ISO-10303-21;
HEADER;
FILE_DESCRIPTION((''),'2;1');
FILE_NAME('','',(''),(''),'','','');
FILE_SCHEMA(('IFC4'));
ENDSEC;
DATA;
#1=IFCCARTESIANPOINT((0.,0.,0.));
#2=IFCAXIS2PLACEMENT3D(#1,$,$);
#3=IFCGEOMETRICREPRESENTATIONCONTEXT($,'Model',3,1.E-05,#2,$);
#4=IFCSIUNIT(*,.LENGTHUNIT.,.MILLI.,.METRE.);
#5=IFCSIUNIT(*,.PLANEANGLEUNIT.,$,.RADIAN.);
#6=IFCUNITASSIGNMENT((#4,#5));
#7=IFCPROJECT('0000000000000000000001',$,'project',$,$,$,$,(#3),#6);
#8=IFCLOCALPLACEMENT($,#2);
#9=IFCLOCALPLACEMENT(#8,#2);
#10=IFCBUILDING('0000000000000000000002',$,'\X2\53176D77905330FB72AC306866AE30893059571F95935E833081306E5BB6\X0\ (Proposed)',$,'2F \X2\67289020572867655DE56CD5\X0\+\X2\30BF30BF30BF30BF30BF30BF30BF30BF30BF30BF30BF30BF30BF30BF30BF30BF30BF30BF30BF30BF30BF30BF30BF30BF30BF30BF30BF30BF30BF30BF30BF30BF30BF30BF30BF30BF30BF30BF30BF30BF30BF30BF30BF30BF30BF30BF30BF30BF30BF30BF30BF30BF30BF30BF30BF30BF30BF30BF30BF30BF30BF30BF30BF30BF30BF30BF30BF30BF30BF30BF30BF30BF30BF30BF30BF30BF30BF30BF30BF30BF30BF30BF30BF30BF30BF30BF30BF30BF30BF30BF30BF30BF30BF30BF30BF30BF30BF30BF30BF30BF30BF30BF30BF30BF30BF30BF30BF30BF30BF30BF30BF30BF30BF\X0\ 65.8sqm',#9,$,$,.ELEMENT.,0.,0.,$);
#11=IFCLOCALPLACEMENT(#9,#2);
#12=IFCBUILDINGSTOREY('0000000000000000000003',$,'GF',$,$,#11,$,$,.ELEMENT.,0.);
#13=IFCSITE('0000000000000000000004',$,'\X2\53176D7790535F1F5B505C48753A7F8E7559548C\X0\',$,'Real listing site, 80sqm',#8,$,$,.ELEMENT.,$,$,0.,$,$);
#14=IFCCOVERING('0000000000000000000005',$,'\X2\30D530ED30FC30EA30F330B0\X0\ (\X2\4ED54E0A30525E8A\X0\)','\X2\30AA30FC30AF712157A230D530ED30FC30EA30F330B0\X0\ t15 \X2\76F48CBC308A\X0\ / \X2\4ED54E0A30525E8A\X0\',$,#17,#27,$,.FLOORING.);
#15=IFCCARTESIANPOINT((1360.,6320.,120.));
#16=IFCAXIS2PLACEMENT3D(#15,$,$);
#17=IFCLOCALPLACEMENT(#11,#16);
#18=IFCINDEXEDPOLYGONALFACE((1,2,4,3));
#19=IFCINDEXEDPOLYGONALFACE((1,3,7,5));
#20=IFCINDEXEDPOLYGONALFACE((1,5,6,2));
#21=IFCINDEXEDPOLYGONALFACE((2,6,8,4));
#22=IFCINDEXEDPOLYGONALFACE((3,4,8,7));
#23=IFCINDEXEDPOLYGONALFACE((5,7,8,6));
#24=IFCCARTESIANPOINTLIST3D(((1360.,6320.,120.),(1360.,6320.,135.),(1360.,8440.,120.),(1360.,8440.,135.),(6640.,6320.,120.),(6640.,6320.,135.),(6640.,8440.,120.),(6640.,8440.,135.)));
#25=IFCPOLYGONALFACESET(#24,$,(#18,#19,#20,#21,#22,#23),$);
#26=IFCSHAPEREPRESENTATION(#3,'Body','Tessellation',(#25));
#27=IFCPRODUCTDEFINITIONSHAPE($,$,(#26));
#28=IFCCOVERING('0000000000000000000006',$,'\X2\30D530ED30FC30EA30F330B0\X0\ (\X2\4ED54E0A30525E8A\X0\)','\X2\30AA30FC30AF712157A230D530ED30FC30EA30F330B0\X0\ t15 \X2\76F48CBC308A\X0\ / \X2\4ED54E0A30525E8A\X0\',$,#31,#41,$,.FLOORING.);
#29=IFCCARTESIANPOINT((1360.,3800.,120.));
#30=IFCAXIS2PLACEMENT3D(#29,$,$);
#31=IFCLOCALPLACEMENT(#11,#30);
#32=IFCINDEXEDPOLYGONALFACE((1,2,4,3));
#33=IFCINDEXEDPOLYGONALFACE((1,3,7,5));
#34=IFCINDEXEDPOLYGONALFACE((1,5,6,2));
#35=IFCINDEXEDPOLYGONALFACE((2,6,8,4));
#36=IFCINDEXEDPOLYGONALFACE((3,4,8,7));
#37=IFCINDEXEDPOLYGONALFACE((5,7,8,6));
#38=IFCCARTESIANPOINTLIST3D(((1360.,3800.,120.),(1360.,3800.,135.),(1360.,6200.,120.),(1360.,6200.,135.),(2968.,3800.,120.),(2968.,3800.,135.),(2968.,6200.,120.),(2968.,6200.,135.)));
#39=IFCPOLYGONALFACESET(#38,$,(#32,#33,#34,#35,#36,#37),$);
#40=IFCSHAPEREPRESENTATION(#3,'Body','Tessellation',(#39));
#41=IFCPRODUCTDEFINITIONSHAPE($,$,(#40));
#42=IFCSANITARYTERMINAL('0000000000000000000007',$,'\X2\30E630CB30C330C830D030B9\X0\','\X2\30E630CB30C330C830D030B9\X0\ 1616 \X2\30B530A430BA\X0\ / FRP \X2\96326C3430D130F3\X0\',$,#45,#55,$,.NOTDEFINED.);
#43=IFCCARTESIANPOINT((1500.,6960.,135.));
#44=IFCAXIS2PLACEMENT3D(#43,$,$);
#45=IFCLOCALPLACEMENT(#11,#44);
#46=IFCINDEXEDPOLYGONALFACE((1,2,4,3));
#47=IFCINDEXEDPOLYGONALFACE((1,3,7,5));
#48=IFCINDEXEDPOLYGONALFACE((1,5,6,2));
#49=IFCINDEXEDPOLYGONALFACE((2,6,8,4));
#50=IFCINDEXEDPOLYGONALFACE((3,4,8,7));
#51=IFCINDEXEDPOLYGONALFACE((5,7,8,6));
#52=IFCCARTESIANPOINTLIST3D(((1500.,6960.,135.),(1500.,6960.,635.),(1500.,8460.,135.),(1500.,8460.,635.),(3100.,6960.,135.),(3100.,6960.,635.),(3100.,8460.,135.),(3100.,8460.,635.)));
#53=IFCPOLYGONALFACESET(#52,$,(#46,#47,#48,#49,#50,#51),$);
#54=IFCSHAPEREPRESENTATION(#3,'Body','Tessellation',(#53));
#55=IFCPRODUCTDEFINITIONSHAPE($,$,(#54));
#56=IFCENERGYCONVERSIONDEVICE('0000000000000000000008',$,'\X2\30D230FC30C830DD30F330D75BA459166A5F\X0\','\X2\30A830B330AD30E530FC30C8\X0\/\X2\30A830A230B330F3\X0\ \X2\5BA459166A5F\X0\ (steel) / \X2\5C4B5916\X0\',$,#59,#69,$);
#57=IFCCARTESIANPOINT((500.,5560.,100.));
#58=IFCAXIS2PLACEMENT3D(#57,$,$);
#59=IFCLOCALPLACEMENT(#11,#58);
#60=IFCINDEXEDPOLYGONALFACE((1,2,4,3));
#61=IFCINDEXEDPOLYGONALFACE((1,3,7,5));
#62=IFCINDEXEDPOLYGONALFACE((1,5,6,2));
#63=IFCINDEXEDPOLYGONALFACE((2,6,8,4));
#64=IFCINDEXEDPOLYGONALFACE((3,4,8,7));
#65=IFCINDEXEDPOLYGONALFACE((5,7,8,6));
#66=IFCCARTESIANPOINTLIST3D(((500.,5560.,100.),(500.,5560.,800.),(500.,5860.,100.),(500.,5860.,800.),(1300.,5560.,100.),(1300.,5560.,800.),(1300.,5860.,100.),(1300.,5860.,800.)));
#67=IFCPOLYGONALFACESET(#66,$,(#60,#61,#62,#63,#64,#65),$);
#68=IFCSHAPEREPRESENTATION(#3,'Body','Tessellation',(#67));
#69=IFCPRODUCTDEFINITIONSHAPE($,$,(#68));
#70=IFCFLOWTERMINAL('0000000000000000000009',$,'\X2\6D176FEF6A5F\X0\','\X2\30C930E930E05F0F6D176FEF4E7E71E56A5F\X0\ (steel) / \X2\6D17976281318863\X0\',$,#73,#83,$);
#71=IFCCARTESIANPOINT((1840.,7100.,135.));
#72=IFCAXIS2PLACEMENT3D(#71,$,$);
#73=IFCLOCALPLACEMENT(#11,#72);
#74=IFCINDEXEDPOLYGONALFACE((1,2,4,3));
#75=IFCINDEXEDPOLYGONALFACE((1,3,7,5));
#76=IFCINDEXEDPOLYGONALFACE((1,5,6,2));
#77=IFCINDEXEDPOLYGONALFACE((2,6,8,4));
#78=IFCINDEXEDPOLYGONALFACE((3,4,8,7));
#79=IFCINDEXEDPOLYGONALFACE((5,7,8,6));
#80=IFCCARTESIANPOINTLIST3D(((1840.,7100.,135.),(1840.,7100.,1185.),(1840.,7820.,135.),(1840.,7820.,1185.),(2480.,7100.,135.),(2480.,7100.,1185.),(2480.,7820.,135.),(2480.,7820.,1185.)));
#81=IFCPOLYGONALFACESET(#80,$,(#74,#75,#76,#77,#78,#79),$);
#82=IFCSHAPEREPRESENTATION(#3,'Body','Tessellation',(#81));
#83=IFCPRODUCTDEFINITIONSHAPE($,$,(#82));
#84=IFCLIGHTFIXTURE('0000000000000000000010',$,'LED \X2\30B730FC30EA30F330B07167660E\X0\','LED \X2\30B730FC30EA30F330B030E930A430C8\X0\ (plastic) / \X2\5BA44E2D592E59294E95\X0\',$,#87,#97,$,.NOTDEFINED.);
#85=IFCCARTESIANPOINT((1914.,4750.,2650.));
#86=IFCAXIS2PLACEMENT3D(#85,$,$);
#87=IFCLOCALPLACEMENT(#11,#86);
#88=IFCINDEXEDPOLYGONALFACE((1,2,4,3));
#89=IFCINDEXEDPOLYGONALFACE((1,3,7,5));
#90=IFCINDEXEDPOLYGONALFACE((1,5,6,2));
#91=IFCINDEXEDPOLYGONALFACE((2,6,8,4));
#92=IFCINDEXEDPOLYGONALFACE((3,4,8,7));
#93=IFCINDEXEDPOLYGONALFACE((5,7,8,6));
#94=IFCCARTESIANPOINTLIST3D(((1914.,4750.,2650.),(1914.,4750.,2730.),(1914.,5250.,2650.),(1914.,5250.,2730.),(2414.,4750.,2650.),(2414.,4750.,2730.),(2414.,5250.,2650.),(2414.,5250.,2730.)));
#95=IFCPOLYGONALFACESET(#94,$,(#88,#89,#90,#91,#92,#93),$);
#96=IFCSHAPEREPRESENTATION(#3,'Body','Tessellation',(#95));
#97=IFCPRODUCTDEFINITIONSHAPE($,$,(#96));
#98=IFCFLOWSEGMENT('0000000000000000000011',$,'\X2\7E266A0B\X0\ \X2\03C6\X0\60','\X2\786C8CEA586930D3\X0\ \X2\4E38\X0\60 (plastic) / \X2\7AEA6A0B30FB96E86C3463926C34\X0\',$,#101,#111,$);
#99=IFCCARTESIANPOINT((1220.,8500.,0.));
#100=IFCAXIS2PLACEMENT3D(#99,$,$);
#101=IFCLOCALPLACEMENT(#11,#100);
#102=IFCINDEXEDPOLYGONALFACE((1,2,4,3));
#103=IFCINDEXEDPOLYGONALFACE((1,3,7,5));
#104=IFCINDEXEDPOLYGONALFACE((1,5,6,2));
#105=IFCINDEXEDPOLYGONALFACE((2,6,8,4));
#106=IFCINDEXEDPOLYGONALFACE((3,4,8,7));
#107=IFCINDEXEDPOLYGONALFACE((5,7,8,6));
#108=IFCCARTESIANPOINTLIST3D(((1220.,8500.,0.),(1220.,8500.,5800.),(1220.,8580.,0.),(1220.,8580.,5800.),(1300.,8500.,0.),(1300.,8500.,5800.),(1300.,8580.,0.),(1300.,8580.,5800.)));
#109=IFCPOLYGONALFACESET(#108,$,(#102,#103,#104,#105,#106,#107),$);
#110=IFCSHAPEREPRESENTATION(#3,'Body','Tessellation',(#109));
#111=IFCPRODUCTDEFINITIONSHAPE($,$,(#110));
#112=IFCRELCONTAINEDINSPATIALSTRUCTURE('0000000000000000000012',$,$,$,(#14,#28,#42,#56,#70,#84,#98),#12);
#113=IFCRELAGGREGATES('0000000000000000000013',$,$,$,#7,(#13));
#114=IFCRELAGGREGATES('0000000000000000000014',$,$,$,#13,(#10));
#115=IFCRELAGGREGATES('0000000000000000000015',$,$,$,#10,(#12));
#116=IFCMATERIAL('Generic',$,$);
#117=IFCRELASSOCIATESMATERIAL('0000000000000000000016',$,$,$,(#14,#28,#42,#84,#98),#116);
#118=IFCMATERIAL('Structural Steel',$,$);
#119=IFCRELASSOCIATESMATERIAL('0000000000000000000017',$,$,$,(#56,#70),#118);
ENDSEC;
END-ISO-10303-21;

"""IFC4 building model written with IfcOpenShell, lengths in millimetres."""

from ifc_helpers import new_model, si_unit, frame, frame_2d, origin, place, context, project, spatial, rectangle, extrude, material, element, save


model = new_model("IFC4")

# Units and contexts
model_context = context("Model", 3, precision=1e-05, world=origin())
ifc_project = project(units=[si_unit("LENGTHUNIT", "METRE", prefix="MILLI"), si_unit("PLANEANGLEUNIT", "RADIAN")], contexts=[model_context])

# Site, building, storey
site_placement = place(None, origin())
site = spatial("IfcSite", under=ifc_project, at=site_placement, Name="北海道弟子屈町美留和", ObjectType="Real listing site, 80sqm", CompositionType="ELEMENT", RefElevation=0.0)
building_placement = place(site_placement, origin())
building = spatial("IfcBuilding", under=site, at=building_placement, Name="北海道・犬と暮らす土間広めの家 (Proposed)", ObjectType="2F 木造在来工法+タタタタタタタタタタタタタタタタタタタタタタタタタタタタタタタタタタタタタタタタタタタタタタタタタタタタタタタタタタタタタタタタタタタタタタタタタタタタタタタタタタタタタタタタタタタタタタタタタタタタタタタタタタタタタタタタタ 65.8sqm", CompositionType="ELEMENT", ElevationOfRefHeight=0.0, ElevationOfTerrain=0.0)
storey_placement = place(building_placement, origin())
storey = spatial("IfcBuildingStorey", under=building, at=storey_placement, Name="GF", CompositionType="ELEMENT", Elevation=0.0)

# Coverings
ifc_material_1 = material(Name="Generic")
covering_1_placement = place(storey_placement, frame((1360.0, 6320.0, 120.0)))
element("IfcCovering", 1, at=covering_1_placement, inside=storey, material=ifc_material_1, Name="フローリング (仕上げ床)", Description="オーク無垢フローリング t15 直貼り / 仕上げ床", PredefinedType="FLOORING", context=model_context, shape_type="SweptSolid", body=[
    extrude(rectangle(XDim=5280.0, YDim=2120.0, at=frame_2d((2640.0, 1060.0))), frame((1360.0, 6320.0, 120.0)), (0.0, 0.0, 1.0), 15.0),
])
covering_2_placement = place(storey_placement, frame((1360.0, 3800.0, 120.0)))
element("IfcCovering", 2, at=covering_2_placement, inside=storey, material=ifc_material_1, Name="フローリング (仕上げ床)", Description="オーク無垢フローリング t15 直貼り / 仕上げ床", PredefinedType="FLOORING", context=model_context, shape_type="SweptSolid", body=[
    extrude(rectangle(XDim=1608.0, YDim=2400.0, at=frame_2d((804.0, 1200.0))), frame((1360.0, 3800.0, 120.0)), (0.0, 0.0, 1.0), 15.0),
])

# Sanitary terminal
sanitary_terminal_placement = place(storey_placement, frame((1500.0, 6960.0, 135.0)))
element("IfcSanitaryTerminal", 3, at=sanitary_terminal_placement, inside=storey, material=ifc_material_1, Name="ユニットバス", Description="ユニットバス 1616 サイズ / FRP 防水パン", PredefinedType="NOTDEFINED", context=model_context, shape_type="SweptSolid", body=[
    extrude(rectangle(XDim=1600.0, YDim=1500.0, at=frame_2d((800.0, 750.0))), frame((1500.0, 6960.0, 135.0)), (0.0, 0.0, 1.0), 500.0),
])

# Shared definitions
ifc_material_2 = material(Name="Structural Steel")

# Energy conversion device
energy_conversion_device_placement = place(storey_placement, frame((500.0, 5560.0, 100.0)))
element("IfcEnergyConversionDevice", 4, at=energy_conversion_device_placement, inside=storey, material=ifc_material_2, Name="ヒートポンプ室外機", Description="エコキュート/エアコン 室外機 (steel) / 屋外", context=model_context, shape_type="SweptSolid", body=[
    extrude(rectangle(XDim=800.0, YDim=300.0, at=frame_2d((400.0, 150.0))), frame((500.0, 5560.0, 100.0)), (0.0, 0.0, 1.0), 700.0),
])

# Flow terminal
flow_terminal_placement = place(storey_placement, frame((1840.0, 7100.0, 135.0)))
element("IfcFlowTerminal", 5, at=flow_terminal_placement, inside=storey, material=ifc_material_2, Name="洗濯機", Description="ドラム式洗濯乾燥機 (steel) / 洗面脱衣", context=model_context, shape_type="SweptSolid", body=[
    extrude(rectangle(XDim=640.0, YDim=720.0, at=frame_2d((320.0, 360.0))), frame((1840.0, 7100.0, 135.0)), (0.0, 0.0, 1.0), 1050.0),
])

# Light fixture
light_fixture_placement = place(storey_placement, frame((1914.0, 4750.0, 2650.0)))
element("IfcLightFixture", 6, at=light_fixture_placement, inside=storey, material=ifc_material_1, Name="LED シーリング照明", Description="LED シーリングライト (plastic) / 室中央天井", PredefinedType="NOTDEFINED", context=model_context, shape_type="SweptSolid", body=[
    extrude(rectangle(XDim=500.0, YDim=500.0, at=frame_2d((250.0, 250.0))), frame((1914.0, 4750.0, 2650.0)), (0.0, 0.0, 1.0), 80.0),
])

# Flow segment
flow_segment_placement = place(storey_placement, frame((1220.0, 8500.0, 0.0)))
element("IfcFlowSegment", 7, at=flow_segment_placement, inside=storey, material=ifc_material_1, Name="縦樋 φ60", Description="硬質塩ビ 丸60 (plastic) / 竪樋・雨水排水", context=model_context, shape_type="SweptSolid", body=[
    extrude(rectangle(XDim=80.0, YDim=80.0, at=frame_2d((40.0, 40.0))), frame((1220.0, 8500.0, 0.0)), (0.0, 0.0, 1.0), 5800.0),
])

save(model, "model.ifc")
